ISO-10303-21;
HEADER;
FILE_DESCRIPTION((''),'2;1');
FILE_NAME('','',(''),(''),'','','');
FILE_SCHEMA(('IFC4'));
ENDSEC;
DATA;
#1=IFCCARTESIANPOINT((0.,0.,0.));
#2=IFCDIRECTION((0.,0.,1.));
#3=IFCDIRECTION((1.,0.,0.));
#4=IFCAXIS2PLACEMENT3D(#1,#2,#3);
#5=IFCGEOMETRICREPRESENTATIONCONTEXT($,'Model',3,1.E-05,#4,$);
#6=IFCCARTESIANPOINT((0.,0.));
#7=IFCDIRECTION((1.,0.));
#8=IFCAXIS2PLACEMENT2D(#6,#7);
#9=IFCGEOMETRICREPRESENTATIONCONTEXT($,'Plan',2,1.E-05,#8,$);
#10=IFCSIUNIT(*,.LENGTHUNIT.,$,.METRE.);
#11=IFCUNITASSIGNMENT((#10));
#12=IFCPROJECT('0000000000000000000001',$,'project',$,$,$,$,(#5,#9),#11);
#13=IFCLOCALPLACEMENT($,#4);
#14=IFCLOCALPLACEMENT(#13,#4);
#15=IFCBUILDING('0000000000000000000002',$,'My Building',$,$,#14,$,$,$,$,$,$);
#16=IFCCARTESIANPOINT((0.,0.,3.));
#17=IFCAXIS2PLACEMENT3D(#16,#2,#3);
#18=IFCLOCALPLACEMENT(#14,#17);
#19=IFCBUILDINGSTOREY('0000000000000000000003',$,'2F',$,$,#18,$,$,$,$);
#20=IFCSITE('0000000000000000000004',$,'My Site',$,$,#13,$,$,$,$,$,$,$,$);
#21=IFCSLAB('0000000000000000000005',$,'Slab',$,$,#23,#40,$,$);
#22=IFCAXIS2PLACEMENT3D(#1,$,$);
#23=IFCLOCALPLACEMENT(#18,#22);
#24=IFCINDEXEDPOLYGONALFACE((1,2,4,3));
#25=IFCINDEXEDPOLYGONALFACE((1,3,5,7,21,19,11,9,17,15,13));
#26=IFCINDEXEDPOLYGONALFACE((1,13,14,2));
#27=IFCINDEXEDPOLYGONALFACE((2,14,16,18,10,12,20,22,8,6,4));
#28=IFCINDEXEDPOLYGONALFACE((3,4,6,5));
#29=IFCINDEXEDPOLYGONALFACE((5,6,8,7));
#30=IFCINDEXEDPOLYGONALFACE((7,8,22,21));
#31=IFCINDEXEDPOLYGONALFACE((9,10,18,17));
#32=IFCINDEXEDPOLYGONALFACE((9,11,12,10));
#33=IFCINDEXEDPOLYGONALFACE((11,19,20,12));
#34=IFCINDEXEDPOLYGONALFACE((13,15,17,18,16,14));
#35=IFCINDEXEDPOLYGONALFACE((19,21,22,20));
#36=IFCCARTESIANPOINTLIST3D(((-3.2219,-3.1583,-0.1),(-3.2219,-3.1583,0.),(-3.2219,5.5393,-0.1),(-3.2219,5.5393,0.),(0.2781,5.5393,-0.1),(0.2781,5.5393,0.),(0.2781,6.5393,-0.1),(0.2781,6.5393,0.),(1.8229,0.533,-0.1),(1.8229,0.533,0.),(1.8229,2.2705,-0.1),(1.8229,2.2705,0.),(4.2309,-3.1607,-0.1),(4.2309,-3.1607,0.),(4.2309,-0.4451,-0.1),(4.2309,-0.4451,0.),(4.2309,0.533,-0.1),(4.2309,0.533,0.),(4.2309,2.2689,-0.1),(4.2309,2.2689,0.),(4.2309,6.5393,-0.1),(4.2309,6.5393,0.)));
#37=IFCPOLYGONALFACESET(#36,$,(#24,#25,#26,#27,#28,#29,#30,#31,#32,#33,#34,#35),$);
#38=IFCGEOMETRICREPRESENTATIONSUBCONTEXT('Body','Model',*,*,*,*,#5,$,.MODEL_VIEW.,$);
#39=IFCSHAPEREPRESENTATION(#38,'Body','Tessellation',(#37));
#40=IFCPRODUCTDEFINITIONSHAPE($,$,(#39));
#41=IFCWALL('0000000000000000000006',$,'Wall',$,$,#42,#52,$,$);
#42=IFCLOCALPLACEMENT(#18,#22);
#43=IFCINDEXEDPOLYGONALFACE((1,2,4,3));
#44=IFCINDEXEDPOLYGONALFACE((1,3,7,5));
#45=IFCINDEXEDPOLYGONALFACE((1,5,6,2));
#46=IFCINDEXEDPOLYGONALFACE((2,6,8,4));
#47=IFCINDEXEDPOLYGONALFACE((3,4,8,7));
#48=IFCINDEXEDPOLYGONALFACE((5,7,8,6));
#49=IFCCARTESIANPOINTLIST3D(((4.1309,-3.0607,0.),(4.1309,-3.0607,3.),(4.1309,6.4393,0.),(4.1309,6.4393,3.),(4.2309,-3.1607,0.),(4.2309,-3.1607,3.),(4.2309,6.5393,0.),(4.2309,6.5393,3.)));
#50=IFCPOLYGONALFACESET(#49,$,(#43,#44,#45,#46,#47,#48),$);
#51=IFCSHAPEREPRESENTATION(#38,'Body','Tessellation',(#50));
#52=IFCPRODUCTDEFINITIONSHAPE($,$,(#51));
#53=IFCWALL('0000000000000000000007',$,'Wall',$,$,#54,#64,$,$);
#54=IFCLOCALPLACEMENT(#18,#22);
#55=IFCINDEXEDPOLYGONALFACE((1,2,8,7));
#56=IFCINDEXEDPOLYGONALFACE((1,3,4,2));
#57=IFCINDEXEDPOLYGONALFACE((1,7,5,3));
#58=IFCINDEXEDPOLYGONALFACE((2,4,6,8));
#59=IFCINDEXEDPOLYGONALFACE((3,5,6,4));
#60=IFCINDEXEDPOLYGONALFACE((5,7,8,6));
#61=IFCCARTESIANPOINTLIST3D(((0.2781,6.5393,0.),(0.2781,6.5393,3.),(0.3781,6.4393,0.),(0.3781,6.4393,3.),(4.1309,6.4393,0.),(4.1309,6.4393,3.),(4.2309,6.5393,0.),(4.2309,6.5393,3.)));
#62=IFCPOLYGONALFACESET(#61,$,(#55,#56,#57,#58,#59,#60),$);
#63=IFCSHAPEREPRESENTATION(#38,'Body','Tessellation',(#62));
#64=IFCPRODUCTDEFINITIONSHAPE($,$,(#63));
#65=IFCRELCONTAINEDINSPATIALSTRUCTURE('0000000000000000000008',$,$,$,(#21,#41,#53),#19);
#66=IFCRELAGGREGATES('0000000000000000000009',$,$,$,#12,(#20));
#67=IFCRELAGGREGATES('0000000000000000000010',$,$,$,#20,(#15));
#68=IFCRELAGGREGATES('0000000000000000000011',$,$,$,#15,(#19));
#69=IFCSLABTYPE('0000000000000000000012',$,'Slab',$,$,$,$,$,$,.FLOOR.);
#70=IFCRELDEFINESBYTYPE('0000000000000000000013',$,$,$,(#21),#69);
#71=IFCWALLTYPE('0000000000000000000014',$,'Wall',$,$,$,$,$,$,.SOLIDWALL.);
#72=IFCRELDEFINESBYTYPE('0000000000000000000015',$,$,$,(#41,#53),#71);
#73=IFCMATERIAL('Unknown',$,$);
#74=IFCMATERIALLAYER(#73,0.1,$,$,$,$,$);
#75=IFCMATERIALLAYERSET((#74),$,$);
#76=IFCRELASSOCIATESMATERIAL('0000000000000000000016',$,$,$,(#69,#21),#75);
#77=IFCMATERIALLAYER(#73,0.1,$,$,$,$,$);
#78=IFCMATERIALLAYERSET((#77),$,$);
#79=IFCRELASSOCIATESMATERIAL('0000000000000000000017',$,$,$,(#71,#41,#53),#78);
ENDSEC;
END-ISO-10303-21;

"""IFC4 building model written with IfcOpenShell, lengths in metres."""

from ifc_helpers import new_model, si_unit, frame, origin_with_axes, origin_2d_with_axis, place, context, subcontext, project, spatial, line, indexed_curve, outline, extrude, material, layer, layer_set, layer_usage, type_object, element, save


model = new_model("IFC4")

# Units and contexts
model_context = context("Model", 3, precision=1e-05, world=origin_with_axes())
plan_context = context("Plan", 2, precision=1e-05, world=origin_2d_with_axis())
body_context_1 = subcontext(model_context, "Body", "Model", "MODEL_VIEW")
ifc_project = project(units=[si_unit("LENGTHUNIT", "METRE")], contexts=[model_context, plan_context])

# Site, building, storey
site_placement = place(None, origin_with_axes())
site = spatial("IfcSite", under=ifc_project, at=site_placement, Name="My Site")
building_placement = place(site_placement, origin_with_axes())
building = spatial("IfcBuilding", under=site, at=building_placement, Name="My Building")
storey_placement = place(building_placement, frame((0.0, 0.0, 3.0), z_axis=(0.0, 0.0, 1.0), x_axis=(1.0, 0.0, 0.0)))
storey = spatial("IfcBuildingStorey", under=building, at=storey_placement, Name="2F")

# Slab
ifc_material = material(Name="Unknown")
ifc_layer_1 = layer(ifc_material, 0.1)
ifc_layer_set_1 = layer_set([ifc_layer_1])
ifc_layer_usage_1 = layer_usage(ifc_layer_set_1, "AXIS3", "POSITIVE", -0.1)
slab_type = type_object("IfcSlabType", Name="Slab", PredefinedType="FLOOR", material=ifc_layer_set_1)
slab_placement = place(storey_placement, frame((-3.2219, -3.1583, 0.0), z_axis=(0.0, 0.0, 1.0), x_axis=(1.0, 0.0, 0.0)))
element("IfcSlab", 1, at=slab_placement, inside=storey, type_object=slab_type, material=ifc_layer_usage_1, Name="Slab", context=body_context_1, shape_type="SweptSolid", body=[
    extrude(outline(indexed_curve([(0.0, 0.0), (0.0, 8.6976), (3.5, 8.6976), (3.5, 9.6976), (7.4528, 9.6976), (7.4528, 5.4272), (5.0448, 5.4288), (5.0448, 3.6912), (7.4528, 3.6912), (7.4528, 2.7132), (7.4528, -0.0024), (0.0, 0.0)])), frame((0.0, 0.0, -0.1), z_axis=(0.0, 0.0, 1.0), x_axis=(1.0, 0.0, 0.0)), (0.0, 0.0, 1.0), 0.1),
])

# Walls
ifc_layer_2 = layer(ifc_material, 0.1)
ifc_layer_set_2 = layer_set([ifc_layer_2])
ifc_layer_usage_2 = layer_usage(ifc_layer_set_2, "AXIS2", "POSITIVE", 0.0)
wall_type = type_object("IfcWallType", Name="Wall", PredefinedType="SOLIDWALL", material=ifc_layer_set_2)
wall_1_placement = place(storey_placement, frame((4.2309, -3.1607, 0.0), z_axis=(0.0, 0.0, 1.0), x_axis=(0.0, 1.0, 0.0)))
element("IfcWall", 2, at=wall_1_placement, inside=storey, type_object=wall_type, material=ifc_layer_usage_2, Name="Wall", context=body_context_1, shape_type="SweptSolid", body=[
    extrude(outline(indexed_curve([(0.0, 0.0), (0.1, 0.1), (9.6, 0.1), (9.7, 0.0)], segments=[line(1, 2, 3, 4, 1)])), origin_with_axes(), (0.0, 0.0, 1.0), 3.0),
])
ifc_layer_usage_3 = layer_usage(ifc_layer_set_2, "AXIS2", "POSITIVE", 0.0)
wall_2_placement = place(storey_placement, frame((4.2309, 6.5393, 0.0), z_axis=(0.0, 0.0, 1.0), x_axis=(-1.0, 0.0, 0.0)))
element("IfcWall", 3, at=wall_2_placement, inside=storey, type_object=wall_type, material=ifc_layer_usage_3, Name="Wall", context=body_context_1, shape_type="SweptSolid", body=[
    extrude(outline(indexed_curve([(0.0, 0.0), (0.1, 0.1), (3.8528, 0.1), (3.9528, 0.0)], segments=[line(1, 2, 3, 4, 1)])), origin_with_axes(), (0.0, 0.0, 1.0), 3.0),
])

save(model, "model.ifc")
